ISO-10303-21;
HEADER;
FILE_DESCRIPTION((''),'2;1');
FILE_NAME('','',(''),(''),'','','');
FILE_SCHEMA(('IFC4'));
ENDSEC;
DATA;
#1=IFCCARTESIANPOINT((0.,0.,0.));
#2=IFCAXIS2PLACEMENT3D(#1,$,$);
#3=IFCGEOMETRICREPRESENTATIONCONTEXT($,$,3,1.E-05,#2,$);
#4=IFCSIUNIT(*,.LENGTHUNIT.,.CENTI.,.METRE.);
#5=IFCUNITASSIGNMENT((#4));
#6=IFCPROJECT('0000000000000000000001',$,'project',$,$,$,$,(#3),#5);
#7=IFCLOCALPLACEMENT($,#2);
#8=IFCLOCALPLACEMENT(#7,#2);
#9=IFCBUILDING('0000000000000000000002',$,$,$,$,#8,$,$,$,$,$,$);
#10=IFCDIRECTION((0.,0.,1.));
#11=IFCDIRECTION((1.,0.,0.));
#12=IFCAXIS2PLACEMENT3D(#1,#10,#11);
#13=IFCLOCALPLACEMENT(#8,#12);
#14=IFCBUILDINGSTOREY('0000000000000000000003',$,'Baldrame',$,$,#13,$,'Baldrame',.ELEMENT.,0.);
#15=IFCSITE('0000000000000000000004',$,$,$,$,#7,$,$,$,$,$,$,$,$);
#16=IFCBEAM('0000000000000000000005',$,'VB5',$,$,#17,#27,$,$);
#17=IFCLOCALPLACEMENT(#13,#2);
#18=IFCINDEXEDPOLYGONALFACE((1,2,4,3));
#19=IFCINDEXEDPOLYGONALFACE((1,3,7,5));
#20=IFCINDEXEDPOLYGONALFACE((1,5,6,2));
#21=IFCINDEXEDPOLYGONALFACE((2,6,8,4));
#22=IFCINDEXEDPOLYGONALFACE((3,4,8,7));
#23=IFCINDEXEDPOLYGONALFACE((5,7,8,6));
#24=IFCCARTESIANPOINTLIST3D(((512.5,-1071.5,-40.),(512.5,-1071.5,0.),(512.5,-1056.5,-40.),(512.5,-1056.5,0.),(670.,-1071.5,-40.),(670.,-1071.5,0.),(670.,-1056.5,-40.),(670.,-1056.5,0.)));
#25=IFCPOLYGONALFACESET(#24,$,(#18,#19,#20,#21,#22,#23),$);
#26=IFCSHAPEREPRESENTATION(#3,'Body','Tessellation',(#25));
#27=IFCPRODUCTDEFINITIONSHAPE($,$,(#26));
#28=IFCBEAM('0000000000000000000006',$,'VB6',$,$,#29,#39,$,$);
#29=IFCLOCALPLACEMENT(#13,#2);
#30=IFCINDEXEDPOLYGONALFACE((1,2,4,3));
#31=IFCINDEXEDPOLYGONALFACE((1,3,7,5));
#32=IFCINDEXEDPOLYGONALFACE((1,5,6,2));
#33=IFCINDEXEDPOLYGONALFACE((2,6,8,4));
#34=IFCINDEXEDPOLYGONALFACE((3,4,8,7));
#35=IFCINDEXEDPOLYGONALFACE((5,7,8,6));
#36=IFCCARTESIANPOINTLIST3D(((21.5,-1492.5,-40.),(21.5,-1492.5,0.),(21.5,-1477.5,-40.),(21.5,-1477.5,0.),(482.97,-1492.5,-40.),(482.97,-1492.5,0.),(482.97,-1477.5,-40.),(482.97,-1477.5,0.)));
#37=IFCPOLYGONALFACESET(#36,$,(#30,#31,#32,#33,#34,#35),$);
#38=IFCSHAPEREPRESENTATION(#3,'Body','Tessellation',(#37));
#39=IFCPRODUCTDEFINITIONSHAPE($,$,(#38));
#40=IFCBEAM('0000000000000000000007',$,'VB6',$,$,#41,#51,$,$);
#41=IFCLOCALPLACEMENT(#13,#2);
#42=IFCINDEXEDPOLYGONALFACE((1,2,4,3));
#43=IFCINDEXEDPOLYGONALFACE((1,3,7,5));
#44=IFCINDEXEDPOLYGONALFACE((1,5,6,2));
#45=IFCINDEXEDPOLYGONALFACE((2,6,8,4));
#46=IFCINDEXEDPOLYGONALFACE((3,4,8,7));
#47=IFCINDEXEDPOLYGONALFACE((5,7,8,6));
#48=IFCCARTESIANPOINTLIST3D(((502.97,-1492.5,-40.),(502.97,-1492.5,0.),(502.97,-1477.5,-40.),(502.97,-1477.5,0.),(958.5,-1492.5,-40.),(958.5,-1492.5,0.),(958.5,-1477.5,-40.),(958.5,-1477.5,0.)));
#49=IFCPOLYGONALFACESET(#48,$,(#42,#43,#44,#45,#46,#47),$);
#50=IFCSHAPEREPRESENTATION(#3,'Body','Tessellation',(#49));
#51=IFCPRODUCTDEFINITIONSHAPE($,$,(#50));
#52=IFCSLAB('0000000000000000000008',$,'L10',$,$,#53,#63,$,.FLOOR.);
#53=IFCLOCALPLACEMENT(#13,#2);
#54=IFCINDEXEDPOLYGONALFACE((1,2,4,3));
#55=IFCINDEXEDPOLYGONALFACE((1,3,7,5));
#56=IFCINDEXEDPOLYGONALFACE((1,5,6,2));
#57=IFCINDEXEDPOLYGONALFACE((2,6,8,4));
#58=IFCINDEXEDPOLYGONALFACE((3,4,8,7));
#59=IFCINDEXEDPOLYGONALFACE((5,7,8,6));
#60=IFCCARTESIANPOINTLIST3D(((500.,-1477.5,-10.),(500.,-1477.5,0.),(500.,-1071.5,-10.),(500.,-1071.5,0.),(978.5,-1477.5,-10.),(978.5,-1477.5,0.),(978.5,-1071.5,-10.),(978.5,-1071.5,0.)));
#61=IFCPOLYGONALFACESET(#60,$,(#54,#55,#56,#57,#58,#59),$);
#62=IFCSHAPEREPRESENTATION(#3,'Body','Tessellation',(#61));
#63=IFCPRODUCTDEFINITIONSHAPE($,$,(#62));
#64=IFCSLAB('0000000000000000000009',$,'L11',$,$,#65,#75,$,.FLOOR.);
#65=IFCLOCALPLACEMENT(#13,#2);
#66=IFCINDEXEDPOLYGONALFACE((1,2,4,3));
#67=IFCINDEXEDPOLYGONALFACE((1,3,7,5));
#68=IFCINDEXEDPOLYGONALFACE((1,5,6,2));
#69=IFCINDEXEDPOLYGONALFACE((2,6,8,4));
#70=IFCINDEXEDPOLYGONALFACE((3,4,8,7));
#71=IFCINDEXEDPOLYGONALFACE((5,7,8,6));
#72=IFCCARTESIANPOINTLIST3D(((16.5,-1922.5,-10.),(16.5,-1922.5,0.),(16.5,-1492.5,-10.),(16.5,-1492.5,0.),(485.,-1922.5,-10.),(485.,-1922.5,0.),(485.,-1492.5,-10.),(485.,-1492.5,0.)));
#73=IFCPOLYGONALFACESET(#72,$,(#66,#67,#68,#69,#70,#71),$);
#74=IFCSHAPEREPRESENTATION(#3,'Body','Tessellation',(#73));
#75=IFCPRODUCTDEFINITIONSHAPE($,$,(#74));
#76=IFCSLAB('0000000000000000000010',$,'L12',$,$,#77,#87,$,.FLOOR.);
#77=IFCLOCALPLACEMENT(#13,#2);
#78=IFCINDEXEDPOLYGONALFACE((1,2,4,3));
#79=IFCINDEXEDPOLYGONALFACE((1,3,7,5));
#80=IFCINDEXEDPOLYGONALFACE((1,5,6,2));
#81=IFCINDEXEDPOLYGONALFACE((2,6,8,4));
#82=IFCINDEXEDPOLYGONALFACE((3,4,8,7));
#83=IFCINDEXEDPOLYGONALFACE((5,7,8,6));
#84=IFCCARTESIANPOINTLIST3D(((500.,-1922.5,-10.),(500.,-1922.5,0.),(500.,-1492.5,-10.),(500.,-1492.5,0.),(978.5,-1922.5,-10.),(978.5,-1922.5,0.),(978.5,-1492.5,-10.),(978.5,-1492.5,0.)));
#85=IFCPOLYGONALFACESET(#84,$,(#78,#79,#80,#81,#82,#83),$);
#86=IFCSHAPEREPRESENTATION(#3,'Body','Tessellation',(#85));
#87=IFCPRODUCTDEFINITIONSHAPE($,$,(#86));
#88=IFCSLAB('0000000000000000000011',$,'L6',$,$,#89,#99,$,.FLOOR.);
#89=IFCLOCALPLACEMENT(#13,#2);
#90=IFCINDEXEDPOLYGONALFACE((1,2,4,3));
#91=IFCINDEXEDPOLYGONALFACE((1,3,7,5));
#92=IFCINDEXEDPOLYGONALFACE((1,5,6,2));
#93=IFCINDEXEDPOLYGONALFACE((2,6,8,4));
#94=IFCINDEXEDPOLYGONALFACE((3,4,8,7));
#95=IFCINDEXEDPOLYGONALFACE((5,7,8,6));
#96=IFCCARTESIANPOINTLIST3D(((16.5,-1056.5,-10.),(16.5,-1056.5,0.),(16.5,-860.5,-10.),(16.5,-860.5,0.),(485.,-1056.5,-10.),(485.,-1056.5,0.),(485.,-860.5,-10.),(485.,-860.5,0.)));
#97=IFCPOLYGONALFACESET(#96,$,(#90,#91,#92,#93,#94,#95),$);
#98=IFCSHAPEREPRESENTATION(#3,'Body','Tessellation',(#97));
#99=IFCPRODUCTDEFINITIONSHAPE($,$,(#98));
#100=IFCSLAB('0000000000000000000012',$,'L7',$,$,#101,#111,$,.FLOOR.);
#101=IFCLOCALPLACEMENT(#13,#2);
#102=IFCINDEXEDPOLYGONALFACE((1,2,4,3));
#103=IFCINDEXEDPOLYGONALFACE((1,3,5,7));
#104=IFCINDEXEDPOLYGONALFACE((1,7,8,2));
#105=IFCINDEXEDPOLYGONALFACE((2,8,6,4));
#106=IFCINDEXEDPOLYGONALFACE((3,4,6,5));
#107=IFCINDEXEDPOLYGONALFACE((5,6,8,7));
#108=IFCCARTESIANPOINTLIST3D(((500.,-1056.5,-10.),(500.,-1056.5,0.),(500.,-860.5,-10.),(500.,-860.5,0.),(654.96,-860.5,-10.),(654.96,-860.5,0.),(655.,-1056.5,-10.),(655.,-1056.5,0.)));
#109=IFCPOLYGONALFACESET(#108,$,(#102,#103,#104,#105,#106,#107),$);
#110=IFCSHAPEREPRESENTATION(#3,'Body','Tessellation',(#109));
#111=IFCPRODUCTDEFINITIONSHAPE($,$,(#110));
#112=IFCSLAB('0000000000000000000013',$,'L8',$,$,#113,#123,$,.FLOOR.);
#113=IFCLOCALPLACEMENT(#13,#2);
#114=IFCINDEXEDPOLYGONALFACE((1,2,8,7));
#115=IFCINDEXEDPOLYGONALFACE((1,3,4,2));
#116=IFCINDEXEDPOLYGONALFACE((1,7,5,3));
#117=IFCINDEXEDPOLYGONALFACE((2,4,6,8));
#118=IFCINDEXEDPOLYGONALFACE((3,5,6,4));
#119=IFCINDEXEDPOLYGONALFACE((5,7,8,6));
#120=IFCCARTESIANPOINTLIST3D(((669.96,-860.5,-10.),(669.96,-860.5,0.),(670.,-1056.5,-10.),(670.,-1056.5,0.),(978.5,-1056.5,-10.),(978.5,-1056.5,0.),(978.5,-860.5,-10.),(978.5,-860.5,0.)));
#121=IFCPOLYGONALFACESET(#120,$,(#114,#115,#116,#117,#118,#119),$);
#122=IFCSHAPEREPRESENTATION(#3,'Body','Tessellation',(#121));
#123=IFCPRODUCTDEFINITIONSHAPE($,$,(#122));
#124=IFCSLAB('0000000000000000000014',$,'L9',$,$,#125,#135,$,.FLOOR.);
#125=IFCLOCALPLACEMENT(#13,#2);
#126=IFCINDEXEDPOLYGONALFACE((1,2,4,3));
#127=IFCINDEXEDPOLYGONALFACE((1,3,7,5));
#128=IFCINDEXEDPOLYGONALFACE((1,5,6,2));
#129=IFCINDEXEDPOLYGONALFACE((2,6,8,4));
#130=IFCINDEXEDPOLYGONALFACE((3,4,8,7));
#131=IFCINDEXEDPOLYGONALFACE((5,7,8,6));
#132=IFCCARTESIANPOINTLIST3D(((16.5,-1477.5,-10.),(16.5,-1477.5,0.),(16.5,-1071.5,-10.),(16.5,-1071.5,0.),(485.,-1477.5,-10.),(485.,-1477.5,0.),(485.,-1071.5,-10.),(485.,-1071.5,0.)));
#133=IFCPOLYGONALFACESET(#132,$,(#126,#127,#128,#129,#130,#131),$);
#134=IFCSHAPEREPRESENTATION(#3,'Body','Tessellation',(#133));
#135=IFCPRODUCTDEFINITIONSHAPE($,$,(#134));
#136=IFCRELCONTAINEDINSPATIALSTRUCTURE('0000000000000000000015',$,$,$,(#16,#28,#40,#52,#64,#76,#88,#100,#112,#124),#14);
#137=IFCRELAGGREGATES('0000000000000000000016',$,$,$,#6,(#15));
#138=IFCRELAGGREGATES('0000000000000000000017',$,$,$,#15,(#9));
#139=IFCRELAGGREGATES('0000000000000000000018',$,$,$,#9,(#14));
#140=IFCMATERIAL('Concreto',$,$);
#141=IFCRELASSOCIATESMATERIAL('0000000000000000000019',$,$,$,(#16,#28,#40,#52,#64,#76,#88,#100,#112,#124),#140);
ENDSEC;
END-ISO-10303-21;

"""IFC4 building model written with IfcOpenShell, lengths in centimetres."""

from ifc_helpers import new_model, si_unit, frame, origin, origin_with_axes, place, context, project, spatial, polyline, outline, extrude, material, element, save


model = new_model("IFC4")

# Units and contexts
context_of_model = context(None, 3, precision=1e-05, world=origin())
ifc_project = project(units=[si_unit("LENGTHUNIT", "METRE", prefix="CENTI")], contexts=[context_of_model])

# Site, building, storey
site_placement = place(None, origin())
site = spatial("IfcSite", under=ifc_project, at=site_placement)
building_placement = place(site_placement, origin())
building = spatial("IfcBuilding", under=site, at=building_placement)
storey_placement = place(building_placement, origin_with_axes())
storey = spatial("IfcBuildingStorey", under=building, at=storey_placement, Name="Baldrame", LongName="Baldrame", CompositionType="ELEMENT", Elevation=0.0)

# Shared definitions
ifc_material = material(Name="Concreto")

# Beams
beam_1_placement = place(storey_placement, frame((591.25, -1064.0, 0.0), z_axis=(0.0, 0.0, 1.0), x_axis=(1.0, 0.0, 0.0)))
element("IfcBeam", 1, at=beam_1_placement, inside=storey, material=ifc_material, Name="VB5", context=context_of_model, shape_type="SolidModel", body=[
    extrude(outline(polyline([(-7.5, -20.0), (7.5, -20.0), (7.5, 20.0), (-7.5, 20.0), (-7.5, -20.0)])), frame((-78.75, 0.0, -20.0), z_axis=(1.0, 0.0, 0.0), x_axis=(0.0, -1.0, 0.0)), (0.0, 0.0, 1.0), 157.5),
])
beam_2_placement = place(storey_placement, frame((252.24, -1485.0, 0.0), z_axis=(0.0, 0.0, 1.0), x_axis=(1.0, 0.0, 0.0)))
element("IfcBeam", 2, at=beam_2_placement, inside=storey, material=ifc_material, Name="VB6", context=context_of_model, shape_type="SolidModel", body=[
    extrude(outline(polyline([(-7.5, -20.0), (7.5, -20.0), (7.5, 20.0), (-7.5, 20.0), (-7.5, -20.0)])), frame((-230.74, 0.0, -20.0), z_axis=(1.0, 0.0, 0.0), x_axis=(0.0, -1.0, 0.0)), (0.0, 0.0, 1.0), 461.47),
])
beam_3_placement = place(storey_placement, frame((730.74, -1485.0, 0.0), z_axis=(0.0, 0.0, 1.0), x_axis=(1.0, 0.0, 0.0)))
element("IfcBeam", 3, at=beam_3_placement, inside=storey, material=ifc_material, Name="VB6", context=context_of_model, shape_type="SolidModel", body=[
    extrude(outline(polyline([(-7.5, -20.0), (7.5, -20.0), (7.5, 20.0), (-7.5, 20.0), (-7.5, -20.0)])), frame((-227.76, 0.0, -20.0), z_axis=(1.0, 0.0, 0.0), x_axis=(0.0, -1.0, 0.0)), (0.0, 0.0, 1.0), 455.53),
])

# Slabs
slab_1_placement = place(storey_placement, frame((739.25, -1274.5, 0.0), z_axis=(0.0, 0.0, 1.0), x_axis=(1.0, 0.0, 0.0)))
element("IfcSlab", 4, at=slab_1_placement, inside=storey, material=ifc_material, Name="L10", PredefinedType="FLOOR", context=context_of_model, shape_type="SolidModel", body=[
    extrude(outline(polyline([(239.25, 203.0), (-239.25, 203.0), (-239.25, -203.0), (239.25, -203.0), (239.25, 203.0), (239.25, 203.0)])), frame((0.0, 0.0, -10.0), z_axis=(0.0, 0.0, 1.0), x_axis=(1.0, 0.0, 0.0)), (0.0, 0.0, 1.0), 10.0),
])
slab_2_placement = place(storey_placement, frame((250.75, -1707.5, 0.0), z_axis=(0.0, 0.0, 1.0), x_axis=(1.0, 0.0, 0.0)))
element("IfcSlab", 5, at=slab_2_placement, inside=storey, material=ifc_material, Name="L11", PredefinedType="FLOOR", context=context_of_model, shape_type="SolidModel", body=[
    extrude(outline(polyline([(234.25, 215.0), (-234.25, 215.0), (-234.25, -215.0), (234.25, -215.0), (234.25, 215.0), (234.25, 215.0)])), frame((0.0, 0.0, -10.0), z_axis=(0.0, 0.0, 1.0), x_axis=(1.0, 0.0, 0.0)), (0.0, 0.0, 1.0), 10.0),
])
slab_3_placement = place(storey_placement, frame((739.25, -1707.5, 0.0), z_axis=(0.0, 0.0, 1.0), x_axis=(1.0, 0.0, 0.0)))
element("IfcSlab", 6, at=slab_3_placement, inside=storey, material=ifc_material, Name="L12", PredefinedType="FLOOR", context=context_of_model, shape_type="SolidModel", body=[
    extrude(outline(polyline([(239.25, 215.0), (-239.25, 215.0), (-239.25, -215.0), (239.25, -215.0), (239.25, 215.0), (239.25, 215.0)])), frame((0.0, 0.0, -10.0), z_axis=(0.0, 0.0, 1.0), x_axis=(1.0, 0.0, 0.0)), (0.0, 0.0, 1.0), 10.0),
])
slab_4_placement = place(storey_placement, frame((250.75, -958.5, 0.0), z_axis=(0.0, 0.0, 1.0), x_axis=(1.0, 0.0, 0.0)))
element("IfcSlab", 7, at=slab_4_placement, inside=storey, material=ifc_material, Name="L6", PredefinedType="FLOOR", context=context_of_model, shape_type="SolidModel", body=[
    extrude(outline(polyline([(234.25, 98.0), (-234.25, 98.0), (-234.25, -98.0), (234.25, -98.0), (234.25, 98.0), (234.25, 98.0)])), frame((0.0, 0.0, -10.0), z_axis=(0.0, 0.0, 1.0), x_axis=(1.0, 0.0, 0.0)), (0.0, 0.0, 1.0), 10.0),
])
slab_5_placement = place(storey_placement, frame((577.5, -958.5, 0.0), z_axis=(0.0, 0.0, 1.0), x_axis=(1.0, 0.0, 0.0)))
element("IfcSlab", 8, at=slab_5_placement, inside=storey, material=ifc_material, Name="L7", PredefinedType="FLOOR", context=context_of_model, shape_type="SolidModel", body=[
    extrude(outline(polyline([(77.5, -98.0), (77.46, 98.0), (-77.5, 98.0), (-77.5, -98.0), (77.5, -98.0), (77.5, -98.0)])), frame((0.0, 0.0, -10.0), z_axis=(0.0, 0.0, 1.0), x_axis=(1.0, 0.0, 0.0)), (0.0, 0.0, 1.0), 10.0),
])
slab_6_placement = place(storey_placement, frame((824.23, -958.5, 0.0), z_axis=(0.0, 0.0, 1.0), x_axis=(1.0, 0.0, 0.0)))
element("IfcSlab", 9, at=slab_6_placement, inside=storey, material=ifc_material, Name="L8", PredefinedType="FLOOR", context=context_of_model, shape_type="SolidModel", body=[
    extrude(outline(polyline([(154.27, 98.0), (-154.27, 98.0), (-154.23, -98.0), (154.27, -98.0), (154.27, 98.0), (154.27, 98.0)])), frame((0.0, 0.0, -10.0), z_axis=(0.0, 0.0, 1.0), x_axis=(1.0, 0.0, 0.0)), (0.0, 0.0, 1.0), 10.0),
])
slab_7_placement = place(storey_placement, frame((250.75, -1274.5, 0.0), z_axis=(0.0, 0.0, 1.0), x_axis=(1.0, 0.0, 0.0)))
element("IfcSlab", 10, at=slab_7_placement, inside=storey, material=ifc_material, Name="L9", PredefinedType="FLOOR", context=context_of_model, shape_type="SolidModel", body=[
    extrude(outline(polyline([(234.25, 203.0), (-234.25, 203.0), (-234.25, -203.0), (234.25, -203.0), (234.25, 203.0), (234.25, 203.0)])), frame((0.0, 0.0, -10.0), z_axis=(0.0, 0.0, 1.0), x_axis=(1.0, 0.0, 0.0)), (0.0, 0.0, 1.0), 10.0),
])

save(model, "model.ifc")
